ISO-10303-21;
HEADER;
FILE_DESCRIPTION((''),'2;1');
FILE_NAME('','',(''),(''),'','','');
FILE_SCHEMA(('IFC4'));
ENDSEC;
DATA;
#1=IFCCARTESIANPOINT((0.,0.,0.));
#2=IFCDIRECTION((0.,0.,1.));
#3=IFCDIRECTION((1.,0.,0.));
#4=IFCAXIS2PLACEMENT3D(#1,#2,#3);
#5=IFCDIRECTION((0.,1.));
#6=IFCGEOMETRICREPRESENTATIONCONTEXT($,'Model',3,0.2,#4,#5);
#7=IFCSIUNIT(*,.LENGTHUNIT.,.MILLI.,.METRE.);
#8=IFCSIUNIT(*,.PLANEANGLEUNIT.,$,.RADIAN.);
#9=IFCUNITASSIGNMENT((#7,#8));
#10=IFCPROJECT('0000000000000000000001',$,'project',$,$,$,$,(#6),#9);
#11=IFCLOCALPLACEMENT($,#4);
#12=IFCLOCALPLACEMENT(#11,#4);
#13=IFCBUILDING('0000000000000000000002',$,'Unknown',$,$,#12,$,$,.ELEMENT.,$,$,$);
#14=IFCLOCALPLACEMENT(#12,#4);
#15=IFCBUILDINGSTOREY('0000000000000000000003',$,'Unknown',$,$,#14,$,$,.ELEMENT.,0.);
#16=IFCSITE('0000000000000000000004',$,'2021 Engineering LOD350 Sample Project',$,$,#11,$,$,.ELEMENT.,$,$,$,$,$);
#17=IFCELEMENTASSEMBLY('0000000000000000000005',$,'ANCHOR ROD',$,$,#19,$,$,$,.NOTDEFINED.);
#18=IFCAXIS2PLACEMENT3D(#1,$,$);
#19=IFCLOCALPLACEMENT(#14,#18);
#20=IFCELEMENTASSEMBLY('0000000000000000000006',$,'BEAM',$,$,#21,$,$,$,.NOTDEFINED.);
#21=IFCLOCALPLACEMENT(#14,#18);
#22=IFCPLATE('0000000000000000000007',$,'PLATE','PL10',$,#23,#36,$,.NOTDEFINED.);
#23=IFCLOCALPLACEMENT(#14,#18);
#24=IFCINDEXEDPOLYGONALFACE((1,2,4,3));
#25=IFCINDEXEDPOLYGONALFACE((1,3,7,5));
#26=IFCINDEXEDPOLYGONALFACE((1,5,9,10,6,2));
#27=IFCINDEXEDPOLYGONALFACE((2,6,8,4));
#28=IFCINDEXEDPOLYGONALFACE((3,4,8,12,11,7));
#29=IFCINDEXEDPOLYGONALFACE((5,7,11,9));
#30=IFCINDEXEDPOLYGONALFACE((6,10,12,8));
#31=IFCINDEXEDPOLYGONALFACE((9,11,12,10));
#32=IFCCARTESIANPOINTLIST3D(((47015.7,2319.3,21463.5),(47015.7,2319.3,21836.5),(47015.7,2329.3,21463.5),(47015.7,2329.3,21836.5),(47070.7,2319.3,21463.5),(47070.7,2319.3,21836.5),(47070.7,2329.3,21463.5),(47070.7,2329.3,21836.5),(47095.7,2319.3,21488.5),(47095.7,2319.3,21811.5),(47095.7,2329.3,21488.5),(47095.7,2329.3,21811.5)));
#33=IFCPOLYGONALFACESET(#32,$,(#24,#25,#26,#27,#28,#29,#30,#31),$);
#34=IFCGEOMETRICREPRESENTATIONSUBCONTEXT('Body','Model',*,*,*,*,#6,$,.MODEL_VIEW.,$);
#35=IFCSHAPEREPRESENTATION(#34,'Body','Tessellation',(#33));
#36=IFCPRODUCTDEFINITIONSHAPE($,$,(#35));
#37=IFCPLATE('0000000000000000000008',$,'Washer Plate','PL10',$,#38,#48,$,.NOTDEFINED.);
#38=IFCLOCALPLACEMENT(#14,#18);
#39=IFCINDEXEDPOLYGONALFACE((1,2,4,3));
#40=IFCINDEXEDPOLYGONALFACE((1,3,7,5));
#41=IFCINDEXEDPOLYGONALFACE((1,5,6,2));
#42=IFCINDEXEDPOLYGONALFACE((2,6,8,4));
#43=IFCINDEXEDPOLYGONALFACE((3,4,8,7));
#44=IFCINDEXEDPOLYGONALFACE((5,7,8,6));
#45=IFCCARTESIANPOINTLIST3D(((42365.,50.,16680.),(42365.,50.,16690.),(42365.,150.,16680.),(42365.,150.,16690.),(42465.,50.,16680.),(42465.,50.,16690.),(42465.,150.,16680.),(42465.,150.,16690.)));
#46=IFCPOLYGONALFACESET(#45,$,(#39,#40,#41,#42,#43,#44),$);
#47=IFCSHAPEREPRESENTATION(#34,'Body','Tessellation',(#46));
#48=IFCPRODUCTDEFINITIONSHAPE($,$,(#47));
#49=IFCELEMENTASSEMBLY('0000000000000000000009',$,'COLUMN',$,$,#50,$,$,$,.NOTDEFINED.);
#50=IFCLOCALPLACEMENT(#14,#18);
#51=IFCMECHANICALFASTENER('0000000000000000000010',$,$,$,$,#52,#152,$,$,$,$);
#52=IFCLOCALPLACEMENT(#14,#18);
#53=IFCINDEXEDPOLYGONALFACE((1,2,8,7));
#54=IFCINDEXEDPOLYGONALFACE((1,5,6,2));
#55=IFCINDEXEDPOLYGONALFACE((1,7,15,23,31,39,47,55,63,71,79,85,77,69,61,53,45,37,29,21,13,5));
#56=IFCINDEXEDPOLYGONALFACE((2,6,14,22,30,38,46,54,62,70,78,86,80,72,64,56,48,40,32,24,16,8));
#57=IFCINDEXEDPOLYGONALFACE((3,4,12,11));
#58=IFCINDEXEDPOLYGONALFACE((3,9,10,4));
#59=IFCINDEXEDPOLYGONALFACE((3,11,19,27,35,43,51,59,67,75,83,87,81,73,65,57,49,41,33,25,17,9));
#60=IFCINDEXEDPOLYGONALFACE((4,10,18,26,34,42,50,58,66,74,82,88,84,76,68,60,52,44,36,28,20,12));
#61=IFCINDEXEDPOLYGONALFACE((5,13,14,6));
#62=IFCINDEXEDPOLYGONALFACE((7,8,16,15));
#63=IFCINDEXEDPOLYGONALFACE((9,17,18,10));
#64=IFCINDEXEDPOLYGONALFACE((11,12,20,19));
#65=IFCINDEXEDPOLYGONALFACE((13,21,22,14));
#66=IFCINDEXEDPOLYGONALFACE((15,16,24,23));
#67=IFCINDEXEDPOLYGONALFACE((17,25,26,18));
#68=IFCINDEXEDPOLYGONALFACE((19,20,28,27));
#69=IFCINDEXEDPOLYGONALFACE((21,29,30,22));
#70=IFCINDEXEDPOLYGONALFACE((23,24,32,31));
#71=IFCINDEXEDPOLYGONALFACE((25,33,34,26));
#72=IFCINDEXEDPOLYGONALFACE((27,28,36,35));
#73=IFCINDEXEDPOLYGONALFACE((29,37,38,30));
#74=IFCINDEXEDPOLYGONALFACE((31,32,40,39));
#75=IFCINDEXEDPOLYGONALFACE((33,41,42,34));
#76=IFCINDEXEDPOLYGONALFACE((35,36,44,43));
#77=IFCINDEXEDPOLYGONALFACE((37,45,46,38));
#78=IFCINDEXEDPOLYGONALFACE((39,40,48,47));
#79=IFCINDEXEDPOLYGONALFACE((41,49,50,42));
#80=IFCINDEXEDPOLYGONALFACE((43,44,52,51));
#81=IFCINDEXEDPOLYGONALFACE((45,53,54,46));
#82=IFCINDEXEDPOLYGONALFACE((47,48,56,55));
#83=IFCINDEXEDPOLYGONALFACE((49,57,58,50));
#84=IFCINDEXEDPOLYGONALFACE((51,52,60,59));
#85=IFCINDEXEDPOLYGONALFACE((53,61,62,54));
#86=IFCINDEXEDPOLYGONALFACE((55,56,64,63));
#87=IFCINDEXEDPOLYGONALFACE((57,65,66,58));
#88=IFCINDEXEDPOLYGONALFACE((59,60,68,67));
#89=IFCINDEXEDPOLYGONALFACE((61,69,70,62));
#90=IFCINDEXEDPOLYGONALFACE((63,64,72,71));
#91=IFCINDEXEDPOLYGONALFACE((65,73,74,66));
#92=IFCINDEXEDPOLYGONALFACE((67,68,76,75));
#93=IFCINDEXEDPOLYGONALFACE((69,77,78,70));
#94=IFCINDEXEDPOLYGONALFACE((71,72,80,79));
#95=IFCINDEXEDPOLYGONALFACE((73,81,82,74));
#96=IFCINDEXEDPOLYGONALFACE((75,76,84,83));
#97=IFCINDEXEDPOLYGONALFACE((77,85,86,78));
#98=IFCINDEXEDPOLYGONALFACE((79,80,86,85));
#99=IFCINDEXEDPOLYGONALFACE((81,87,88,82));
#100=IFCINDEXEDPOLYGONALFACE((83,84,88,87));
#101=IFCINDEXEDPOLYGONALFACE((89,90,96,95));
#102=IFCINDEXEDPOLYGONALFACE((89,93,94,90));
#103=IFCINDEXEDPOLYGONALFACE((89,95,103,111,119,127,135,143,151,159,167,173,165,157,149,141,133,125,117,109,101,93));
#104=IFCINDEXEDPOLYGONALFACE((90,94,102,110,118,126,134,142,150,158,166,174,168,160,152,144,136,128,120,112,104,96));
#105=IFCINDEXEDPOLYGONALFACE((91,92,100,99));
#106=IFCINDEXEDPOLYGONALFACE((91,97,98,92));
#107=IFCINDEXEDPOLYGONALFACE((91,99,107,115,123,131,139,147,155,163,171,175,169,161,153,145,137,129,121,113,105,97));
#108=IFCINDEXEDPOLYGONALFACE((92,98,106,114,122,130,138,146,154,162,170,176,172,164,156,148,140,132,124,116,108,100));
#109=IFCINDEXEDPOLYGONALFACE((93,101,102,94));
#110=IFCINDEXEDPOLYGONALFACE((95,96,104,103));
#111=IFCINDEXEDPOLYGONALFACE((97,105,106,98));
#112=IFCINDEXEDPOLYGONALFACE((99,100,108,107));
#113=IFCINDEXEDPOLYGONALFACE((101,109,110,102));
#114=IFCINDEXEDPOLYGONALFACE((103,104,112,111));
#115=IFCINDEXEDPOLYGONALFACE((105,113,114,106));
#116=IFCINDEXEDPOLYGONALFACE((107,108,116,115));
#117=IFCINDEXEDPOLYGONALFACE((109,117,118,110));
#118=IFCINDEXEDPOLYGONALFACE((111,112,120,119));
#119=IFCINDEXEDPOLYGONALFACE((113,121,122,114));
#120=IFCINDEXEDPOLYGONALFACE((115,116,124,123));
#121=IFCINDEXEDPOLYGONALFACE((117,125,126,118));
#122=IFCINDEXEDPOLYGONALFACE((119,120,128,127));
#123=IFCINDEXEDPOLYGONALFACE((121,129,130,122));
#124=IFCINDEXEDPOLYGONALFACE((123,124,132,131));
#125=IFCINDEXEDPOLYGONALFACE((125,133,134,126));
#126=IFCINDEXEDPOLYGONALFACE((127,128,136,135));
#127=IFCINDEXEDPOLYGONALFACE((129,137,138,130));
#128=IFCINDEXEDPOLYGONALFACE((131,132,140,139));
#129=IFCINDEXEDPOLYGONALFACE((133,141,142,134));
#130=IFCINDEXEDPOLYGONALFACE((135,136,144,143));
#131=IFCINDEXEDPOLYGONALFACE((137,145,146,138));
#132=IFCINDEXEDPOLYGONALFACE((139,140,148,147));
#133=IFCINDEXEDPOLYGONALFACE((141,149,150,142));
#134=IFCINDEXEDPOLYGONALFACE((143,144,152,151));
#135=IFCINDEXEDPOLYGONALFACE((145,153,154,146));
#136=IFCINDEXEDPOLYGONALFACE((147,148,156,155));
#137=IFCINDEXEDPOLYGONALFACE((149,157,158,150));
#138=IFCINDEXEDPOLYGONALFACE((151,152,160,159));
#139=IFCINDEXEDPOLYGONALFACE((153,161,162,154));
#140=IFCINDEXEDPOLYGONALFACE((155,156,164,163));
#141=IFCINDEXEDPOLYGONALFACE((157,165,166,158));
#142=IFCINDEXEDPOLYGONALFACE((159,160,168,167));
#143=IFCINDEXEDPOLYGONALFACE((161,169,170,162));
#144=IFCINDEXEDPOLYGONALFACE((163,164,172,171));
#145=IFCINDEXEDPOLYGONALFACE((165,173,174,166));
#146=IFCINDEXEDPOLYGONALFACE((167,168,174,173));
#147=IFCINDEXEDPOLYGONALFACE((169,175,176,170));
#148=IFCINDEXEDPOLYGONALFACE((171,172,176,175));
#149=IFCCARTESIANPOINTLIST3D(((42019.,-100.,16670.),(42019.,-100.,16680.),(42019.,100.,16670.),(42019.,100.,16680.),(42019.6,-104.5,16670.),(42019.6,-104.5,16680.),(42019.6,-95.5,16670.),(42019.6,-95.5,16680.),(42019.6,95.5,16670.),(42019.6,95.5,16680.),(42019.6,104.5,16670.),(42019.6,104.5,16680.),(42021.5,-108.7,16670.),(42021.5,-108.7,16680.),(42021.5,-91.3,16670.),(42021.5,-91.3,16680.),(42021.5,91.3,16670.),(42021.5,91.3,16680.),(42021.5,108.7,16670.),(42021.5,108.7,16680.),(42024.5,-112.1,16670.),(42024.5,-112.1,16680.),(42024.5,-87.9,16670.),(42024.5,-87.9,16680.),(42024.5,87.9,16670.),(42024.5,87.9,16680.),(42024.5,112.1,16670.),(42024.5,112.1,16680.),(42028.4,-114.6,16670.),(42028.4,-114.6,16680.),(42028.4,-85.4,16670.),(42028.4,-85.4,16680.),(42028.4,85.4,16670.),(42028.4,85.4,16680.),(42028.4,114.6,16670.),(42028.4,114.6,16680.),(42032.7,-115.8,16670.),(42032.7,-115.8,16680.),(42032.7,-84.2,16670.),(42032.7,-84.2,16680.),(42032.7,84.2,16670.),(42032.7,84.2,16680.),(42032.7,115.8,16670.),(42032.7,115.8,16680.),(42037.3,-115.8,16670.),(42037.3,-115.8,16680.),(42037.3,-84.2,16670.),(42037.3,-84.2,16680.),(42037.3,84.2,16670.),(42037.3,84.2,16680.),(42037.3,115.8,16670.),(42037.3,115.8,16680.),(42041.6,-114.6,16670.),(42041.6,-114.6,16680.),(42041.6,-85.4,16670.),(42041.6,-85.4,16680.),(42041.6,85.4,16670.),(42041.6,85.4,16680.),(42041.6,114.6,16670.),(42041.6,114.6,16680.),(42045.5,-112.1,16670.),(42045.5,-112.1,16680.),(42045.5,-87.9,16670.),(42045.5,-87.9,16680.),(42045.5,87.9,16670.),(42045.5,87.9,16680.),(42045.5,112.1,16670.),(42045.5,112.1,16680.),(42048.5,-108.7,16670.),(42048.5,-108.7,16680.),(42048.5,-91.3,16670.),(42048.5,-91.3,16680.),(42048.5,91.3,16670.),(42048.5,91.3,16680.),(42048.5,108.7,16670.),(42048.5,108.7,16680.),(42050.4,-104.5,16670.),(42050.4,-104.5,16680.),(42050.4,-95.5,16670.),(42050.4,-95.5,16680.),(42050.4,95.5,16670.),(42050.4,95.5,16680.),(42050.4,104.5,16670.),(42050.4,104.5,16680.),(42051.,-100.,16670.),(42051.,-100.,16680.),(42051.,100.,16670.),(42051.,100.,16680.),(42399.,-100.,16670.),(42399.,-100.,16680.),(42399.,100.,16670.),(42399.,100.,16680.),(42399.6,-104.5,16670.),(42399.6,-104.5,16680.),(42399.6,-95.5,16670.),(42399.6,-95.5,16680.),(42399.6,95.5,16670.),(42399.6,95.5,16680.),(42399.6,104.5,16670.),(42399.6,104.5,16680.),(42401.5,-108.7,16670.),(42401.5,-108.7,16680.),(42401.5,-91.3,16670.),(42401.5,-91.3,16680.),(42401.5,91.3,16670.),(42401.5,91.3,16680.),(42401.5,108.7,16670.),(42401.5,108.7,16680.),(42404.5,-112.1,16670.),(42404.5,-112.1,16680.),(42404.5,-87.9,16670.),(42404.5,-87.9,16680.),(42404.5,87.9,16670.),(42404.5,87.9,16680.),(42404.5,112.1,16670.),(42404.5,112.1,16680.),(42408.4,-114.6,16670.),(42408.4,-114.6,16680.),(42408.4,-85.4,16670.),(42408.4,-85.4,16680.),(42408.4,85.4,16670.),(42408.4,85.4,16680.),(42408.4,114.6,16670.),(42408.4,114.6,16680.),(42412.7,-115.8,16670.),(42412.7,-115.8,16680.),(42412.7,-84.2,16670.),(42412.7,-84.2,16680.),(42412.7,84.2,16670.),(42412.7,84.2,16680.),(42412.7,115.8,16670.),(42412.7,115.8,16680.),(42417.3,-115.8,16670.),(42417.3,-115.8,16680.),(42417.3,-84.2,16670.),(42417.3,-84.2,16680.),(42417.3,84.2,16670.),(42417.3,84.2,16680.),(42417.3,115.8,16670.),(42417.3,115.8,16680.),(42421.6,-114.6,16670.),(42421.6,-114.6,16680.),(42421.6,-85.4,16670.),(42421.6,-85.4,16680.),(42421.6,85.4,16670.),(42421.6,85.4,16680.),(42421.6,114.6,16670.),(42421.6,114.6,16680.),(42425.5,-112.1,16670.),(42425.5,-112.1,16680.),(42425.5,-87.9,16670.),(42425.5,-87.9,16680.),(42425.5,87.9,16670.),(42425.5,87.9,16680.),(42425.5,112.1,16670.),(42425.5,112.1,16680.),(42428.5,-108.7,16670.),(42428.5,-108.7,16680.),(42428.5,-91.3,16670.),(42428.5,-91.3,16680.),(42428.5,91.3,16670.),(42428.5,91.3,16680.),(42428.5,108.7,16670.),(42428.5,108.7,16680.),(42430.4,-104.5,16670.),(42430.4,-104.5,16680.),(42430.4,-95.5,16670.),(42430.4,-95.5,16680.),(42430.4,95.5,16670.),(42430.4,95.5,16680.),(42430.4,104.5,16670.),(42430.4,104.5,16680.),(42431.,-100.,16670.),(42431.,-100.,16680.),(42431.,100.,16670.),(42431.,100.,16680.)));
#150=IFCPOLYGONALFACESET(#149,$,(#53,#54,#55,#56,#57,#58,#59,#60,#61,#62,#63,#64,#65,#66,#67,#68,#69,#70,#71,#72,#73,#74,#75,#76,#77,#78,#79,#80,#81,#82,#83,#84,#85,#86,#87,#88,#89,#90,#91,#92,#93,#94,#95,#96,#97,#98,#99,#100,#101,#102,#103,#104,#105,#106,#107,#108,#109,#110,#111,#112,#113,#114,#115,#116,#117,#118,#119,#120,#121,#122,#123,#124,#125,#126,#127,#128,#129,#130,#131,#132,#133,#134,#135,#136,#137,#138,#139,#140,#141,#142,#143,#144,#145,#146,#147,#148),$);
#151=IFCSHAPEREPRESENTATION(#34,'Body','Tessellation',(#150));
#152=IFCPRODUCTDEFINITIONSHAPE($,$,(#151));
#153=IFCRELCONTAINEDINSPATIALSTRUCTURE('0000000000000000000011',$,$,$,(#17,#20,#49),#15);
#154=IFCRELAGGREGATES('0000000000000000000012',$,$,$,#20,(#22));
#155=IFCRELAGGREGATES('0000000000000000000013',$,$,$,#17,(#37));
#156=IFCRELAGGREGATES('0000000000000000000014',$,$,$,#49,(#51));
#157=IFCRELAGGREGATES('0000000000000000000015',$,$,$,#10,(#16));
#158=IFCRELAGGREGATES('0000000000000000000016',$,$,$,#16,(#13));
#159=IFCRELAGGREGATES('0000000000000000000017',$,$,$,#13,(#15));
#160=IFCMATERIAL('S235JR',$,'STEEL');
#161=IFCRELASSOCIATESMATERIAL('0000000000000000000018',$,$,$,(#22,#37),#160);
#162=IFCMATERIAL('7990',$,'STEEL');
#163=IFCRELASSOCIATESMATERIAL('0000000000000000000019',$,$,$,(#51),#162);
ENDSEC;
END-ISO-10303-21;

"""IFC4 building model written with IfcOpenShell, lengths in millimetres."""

from ifc_helpers import new_model, si_unit, direction, frame, origin_with_axes, place, context, subcontext, project, spatial, line, arc, indexed_curve, outline, extrude, source, transform, mapped, material, element, aggregate, save


model = new_model("IFC4")

# Units and contexts
model_context = context("Model", 3, precision=0.2, world=origin_with_axes(), true_north=direction((0.0, 1.0)))
body_context = subcontext(model_context, "Body", "Model", "MODEL_VIEW")
ifc_project = project(units=[si_unit("LENGTHUNIT", "METRE", prefix="MILLI"), si_unit("PLANEANGLEUNIT", "RADIAN")], contexts=[model_context])

# Site, building, storey
site_placement = place(None, origin_with_axes())
site = spatial("IfcSite", under=ifc_project, at=site_placement, Name="2021 Engineering LOD350 Sample Project", CompositionType="ELEMENT")
building_placement = place(site_placement, origin_with_axes())
building = spatial("IfcBuilding", under=site, at=building_placement, Name="Unknown", CompositionType="ELEMENT")
storey_placement = place(building_placement, origin_with_axes())
storey = spatial("IfcBuildingStorey", under=building, at=storey_placement, Name="Unknown", CompositionType="ELEMENT", Elevation=0.0)

# Shared definitions
ifc_material_1 = material(Name="S235JR", Category="STEEL")

# Element assembly
assembly_1_placement = place(storey_placement, frame((42415.0, 100.0, 16730.0), z_axis=(1.0, 0.0, 0.0), x_axis=(0.0, 0.0, -1.0)))
assembly_1 = element("IfcElementAssembly", 1, at=assembly_1_placement, inside=storey, Name="ANCHOR ROD", PredefinedType="NOTDEFINED")

# Element assembly, plate
assembly_2_placement = place(storey_placement, frame((47100.0, 0.0, 21650.0), z_axis=(1.0, 0.0, 0.0), x_axis=(0.0, 1.0, 0.0)))
assembly_2 = element("IfcElementAssembly", 2, at=assembly_2_placement, inside=storey, Name="BEAM", PredefinedType="NOTDEFINED")
plate_1_placement = place(assembly_2_placement, frame((2324.3, -186.5, -4.3), z_axis=(1.0, 0.0, 0.0), x_axis=(0.0, 0.0, -1.0)))
plate_1 = element("IfcPlate", 3, at=plate_1_placement, material=ifc_material_1, Name="PLATE", Description="PL10", PredefinedType="NOTDEFINED", context=body_context, shape_type="SolidModel", body=[
    extrude(outline(indexed_curve([(0.0, 25.0), (25.0, 0.0), (80.0, 0.0), (80.0, 373.0), (25.0, 373.0), (0.0, 348.0)], segments=[line(1, 2, 3, 4, 5, 6, 1)])), frame((0.0, 0.0, 5.0), z_axis=(0.0, 0.0, 1.0), x_axis=(1.0, 0.0, 0.0)), (0.0, 0.0, -1.0), 10.0),
])
aggregate(assembly_2, [plate_1])

# Plate
plate_2_placement = place(assembly_1_placement, frame((45.0, 50.0, 50.0), z_axis=(1.0, 0.0, 0.0), x_axis=(0.0, -1.0, 0.0)))
plate_2 = element("IfcPlate", 4, at=plate_2_placement, material=ifc_material_1, Name="Washer Plate", Description="PL10", PredefinedType="NOTDEFINED", context=body_context, shape_type="SolidModel", body=[
    extrude(outline(indexed_curve([(0.0, 0.0), (100.0, 0.0), (100.0, 100.0), (0.0, 100.0)], segments=[line(1, 2, 3, 4, 1)])), frame((0.0, 0.0, 5.0), z_axis=(0.0, 0.0, 1.0), x_axis=(1.0, 0.0, 0.0)), (0.0, 0.0, -1.0), 10.0),
])
aggregate(assembly_1, [plate_2])

# Element assembly, mechanical fastener
assembly_3_placement = place(storey_placement, frame((42225.0, 0.0, 16200.0), z_axis=(-1.0, 0.0, 0.0), x_axis=(0.0, 0.0, 1.0)))
assembly_3 = element("IfcElementAssembly", 5, at=assembly_3_placement, inside=storey, Name="COLUMN", PredefinedType="NOTDEFINED")
ifc_material_2 = material(Name="7990", Category="STEEL")
shared_shape_1 = source(origin_with_axes(), body_context, "Body", "SweptSolid", [
    extrude(outline(indexed_curve([(16.0, 0.0), (0.0, 16.0), (-16.0, 0.0), (0.0, -16.0)], segments=[arc(1, 2, 3), arc(3, 4, 1)])), frame((0.0, 0.0, 10.0), z_axis=(0.0, 0.0, -1.0), x_axis=(0.0, 1.0, 0.0)), (0.0, 0.0, 1.0), 10.0),
])
mechanical_fastener_1_placement = place(assembly_3_placement, frame((480.0, 200.0, 0.0), z_axis=(-1.0, 0.0, 0.0), x_axis=(0.0, -1.0, 0.0)))
mechanical_fastener_1 = element("IfcMechanicalFastener", 6, at=mechanical_fastener_1_placement, material=ifc_material_2, context=body_context, shape_type="MappedRepresentation", body=[
    mapped(shared_shape_1, transform((100.0, -190.0, 0.0))),
    mapped(shared_shape_1, transform((100.0, 190.0, 0.0))),
    mapped(shared_shape_1, transform((300.0, -190.0, 0.0))),
    mapped(shared_shape_1, transform((300.0, 190.0, 0.0))),
])
aggregate(assembly_3, [mechanical_fastener_1])

save(model, "model.ifc")
